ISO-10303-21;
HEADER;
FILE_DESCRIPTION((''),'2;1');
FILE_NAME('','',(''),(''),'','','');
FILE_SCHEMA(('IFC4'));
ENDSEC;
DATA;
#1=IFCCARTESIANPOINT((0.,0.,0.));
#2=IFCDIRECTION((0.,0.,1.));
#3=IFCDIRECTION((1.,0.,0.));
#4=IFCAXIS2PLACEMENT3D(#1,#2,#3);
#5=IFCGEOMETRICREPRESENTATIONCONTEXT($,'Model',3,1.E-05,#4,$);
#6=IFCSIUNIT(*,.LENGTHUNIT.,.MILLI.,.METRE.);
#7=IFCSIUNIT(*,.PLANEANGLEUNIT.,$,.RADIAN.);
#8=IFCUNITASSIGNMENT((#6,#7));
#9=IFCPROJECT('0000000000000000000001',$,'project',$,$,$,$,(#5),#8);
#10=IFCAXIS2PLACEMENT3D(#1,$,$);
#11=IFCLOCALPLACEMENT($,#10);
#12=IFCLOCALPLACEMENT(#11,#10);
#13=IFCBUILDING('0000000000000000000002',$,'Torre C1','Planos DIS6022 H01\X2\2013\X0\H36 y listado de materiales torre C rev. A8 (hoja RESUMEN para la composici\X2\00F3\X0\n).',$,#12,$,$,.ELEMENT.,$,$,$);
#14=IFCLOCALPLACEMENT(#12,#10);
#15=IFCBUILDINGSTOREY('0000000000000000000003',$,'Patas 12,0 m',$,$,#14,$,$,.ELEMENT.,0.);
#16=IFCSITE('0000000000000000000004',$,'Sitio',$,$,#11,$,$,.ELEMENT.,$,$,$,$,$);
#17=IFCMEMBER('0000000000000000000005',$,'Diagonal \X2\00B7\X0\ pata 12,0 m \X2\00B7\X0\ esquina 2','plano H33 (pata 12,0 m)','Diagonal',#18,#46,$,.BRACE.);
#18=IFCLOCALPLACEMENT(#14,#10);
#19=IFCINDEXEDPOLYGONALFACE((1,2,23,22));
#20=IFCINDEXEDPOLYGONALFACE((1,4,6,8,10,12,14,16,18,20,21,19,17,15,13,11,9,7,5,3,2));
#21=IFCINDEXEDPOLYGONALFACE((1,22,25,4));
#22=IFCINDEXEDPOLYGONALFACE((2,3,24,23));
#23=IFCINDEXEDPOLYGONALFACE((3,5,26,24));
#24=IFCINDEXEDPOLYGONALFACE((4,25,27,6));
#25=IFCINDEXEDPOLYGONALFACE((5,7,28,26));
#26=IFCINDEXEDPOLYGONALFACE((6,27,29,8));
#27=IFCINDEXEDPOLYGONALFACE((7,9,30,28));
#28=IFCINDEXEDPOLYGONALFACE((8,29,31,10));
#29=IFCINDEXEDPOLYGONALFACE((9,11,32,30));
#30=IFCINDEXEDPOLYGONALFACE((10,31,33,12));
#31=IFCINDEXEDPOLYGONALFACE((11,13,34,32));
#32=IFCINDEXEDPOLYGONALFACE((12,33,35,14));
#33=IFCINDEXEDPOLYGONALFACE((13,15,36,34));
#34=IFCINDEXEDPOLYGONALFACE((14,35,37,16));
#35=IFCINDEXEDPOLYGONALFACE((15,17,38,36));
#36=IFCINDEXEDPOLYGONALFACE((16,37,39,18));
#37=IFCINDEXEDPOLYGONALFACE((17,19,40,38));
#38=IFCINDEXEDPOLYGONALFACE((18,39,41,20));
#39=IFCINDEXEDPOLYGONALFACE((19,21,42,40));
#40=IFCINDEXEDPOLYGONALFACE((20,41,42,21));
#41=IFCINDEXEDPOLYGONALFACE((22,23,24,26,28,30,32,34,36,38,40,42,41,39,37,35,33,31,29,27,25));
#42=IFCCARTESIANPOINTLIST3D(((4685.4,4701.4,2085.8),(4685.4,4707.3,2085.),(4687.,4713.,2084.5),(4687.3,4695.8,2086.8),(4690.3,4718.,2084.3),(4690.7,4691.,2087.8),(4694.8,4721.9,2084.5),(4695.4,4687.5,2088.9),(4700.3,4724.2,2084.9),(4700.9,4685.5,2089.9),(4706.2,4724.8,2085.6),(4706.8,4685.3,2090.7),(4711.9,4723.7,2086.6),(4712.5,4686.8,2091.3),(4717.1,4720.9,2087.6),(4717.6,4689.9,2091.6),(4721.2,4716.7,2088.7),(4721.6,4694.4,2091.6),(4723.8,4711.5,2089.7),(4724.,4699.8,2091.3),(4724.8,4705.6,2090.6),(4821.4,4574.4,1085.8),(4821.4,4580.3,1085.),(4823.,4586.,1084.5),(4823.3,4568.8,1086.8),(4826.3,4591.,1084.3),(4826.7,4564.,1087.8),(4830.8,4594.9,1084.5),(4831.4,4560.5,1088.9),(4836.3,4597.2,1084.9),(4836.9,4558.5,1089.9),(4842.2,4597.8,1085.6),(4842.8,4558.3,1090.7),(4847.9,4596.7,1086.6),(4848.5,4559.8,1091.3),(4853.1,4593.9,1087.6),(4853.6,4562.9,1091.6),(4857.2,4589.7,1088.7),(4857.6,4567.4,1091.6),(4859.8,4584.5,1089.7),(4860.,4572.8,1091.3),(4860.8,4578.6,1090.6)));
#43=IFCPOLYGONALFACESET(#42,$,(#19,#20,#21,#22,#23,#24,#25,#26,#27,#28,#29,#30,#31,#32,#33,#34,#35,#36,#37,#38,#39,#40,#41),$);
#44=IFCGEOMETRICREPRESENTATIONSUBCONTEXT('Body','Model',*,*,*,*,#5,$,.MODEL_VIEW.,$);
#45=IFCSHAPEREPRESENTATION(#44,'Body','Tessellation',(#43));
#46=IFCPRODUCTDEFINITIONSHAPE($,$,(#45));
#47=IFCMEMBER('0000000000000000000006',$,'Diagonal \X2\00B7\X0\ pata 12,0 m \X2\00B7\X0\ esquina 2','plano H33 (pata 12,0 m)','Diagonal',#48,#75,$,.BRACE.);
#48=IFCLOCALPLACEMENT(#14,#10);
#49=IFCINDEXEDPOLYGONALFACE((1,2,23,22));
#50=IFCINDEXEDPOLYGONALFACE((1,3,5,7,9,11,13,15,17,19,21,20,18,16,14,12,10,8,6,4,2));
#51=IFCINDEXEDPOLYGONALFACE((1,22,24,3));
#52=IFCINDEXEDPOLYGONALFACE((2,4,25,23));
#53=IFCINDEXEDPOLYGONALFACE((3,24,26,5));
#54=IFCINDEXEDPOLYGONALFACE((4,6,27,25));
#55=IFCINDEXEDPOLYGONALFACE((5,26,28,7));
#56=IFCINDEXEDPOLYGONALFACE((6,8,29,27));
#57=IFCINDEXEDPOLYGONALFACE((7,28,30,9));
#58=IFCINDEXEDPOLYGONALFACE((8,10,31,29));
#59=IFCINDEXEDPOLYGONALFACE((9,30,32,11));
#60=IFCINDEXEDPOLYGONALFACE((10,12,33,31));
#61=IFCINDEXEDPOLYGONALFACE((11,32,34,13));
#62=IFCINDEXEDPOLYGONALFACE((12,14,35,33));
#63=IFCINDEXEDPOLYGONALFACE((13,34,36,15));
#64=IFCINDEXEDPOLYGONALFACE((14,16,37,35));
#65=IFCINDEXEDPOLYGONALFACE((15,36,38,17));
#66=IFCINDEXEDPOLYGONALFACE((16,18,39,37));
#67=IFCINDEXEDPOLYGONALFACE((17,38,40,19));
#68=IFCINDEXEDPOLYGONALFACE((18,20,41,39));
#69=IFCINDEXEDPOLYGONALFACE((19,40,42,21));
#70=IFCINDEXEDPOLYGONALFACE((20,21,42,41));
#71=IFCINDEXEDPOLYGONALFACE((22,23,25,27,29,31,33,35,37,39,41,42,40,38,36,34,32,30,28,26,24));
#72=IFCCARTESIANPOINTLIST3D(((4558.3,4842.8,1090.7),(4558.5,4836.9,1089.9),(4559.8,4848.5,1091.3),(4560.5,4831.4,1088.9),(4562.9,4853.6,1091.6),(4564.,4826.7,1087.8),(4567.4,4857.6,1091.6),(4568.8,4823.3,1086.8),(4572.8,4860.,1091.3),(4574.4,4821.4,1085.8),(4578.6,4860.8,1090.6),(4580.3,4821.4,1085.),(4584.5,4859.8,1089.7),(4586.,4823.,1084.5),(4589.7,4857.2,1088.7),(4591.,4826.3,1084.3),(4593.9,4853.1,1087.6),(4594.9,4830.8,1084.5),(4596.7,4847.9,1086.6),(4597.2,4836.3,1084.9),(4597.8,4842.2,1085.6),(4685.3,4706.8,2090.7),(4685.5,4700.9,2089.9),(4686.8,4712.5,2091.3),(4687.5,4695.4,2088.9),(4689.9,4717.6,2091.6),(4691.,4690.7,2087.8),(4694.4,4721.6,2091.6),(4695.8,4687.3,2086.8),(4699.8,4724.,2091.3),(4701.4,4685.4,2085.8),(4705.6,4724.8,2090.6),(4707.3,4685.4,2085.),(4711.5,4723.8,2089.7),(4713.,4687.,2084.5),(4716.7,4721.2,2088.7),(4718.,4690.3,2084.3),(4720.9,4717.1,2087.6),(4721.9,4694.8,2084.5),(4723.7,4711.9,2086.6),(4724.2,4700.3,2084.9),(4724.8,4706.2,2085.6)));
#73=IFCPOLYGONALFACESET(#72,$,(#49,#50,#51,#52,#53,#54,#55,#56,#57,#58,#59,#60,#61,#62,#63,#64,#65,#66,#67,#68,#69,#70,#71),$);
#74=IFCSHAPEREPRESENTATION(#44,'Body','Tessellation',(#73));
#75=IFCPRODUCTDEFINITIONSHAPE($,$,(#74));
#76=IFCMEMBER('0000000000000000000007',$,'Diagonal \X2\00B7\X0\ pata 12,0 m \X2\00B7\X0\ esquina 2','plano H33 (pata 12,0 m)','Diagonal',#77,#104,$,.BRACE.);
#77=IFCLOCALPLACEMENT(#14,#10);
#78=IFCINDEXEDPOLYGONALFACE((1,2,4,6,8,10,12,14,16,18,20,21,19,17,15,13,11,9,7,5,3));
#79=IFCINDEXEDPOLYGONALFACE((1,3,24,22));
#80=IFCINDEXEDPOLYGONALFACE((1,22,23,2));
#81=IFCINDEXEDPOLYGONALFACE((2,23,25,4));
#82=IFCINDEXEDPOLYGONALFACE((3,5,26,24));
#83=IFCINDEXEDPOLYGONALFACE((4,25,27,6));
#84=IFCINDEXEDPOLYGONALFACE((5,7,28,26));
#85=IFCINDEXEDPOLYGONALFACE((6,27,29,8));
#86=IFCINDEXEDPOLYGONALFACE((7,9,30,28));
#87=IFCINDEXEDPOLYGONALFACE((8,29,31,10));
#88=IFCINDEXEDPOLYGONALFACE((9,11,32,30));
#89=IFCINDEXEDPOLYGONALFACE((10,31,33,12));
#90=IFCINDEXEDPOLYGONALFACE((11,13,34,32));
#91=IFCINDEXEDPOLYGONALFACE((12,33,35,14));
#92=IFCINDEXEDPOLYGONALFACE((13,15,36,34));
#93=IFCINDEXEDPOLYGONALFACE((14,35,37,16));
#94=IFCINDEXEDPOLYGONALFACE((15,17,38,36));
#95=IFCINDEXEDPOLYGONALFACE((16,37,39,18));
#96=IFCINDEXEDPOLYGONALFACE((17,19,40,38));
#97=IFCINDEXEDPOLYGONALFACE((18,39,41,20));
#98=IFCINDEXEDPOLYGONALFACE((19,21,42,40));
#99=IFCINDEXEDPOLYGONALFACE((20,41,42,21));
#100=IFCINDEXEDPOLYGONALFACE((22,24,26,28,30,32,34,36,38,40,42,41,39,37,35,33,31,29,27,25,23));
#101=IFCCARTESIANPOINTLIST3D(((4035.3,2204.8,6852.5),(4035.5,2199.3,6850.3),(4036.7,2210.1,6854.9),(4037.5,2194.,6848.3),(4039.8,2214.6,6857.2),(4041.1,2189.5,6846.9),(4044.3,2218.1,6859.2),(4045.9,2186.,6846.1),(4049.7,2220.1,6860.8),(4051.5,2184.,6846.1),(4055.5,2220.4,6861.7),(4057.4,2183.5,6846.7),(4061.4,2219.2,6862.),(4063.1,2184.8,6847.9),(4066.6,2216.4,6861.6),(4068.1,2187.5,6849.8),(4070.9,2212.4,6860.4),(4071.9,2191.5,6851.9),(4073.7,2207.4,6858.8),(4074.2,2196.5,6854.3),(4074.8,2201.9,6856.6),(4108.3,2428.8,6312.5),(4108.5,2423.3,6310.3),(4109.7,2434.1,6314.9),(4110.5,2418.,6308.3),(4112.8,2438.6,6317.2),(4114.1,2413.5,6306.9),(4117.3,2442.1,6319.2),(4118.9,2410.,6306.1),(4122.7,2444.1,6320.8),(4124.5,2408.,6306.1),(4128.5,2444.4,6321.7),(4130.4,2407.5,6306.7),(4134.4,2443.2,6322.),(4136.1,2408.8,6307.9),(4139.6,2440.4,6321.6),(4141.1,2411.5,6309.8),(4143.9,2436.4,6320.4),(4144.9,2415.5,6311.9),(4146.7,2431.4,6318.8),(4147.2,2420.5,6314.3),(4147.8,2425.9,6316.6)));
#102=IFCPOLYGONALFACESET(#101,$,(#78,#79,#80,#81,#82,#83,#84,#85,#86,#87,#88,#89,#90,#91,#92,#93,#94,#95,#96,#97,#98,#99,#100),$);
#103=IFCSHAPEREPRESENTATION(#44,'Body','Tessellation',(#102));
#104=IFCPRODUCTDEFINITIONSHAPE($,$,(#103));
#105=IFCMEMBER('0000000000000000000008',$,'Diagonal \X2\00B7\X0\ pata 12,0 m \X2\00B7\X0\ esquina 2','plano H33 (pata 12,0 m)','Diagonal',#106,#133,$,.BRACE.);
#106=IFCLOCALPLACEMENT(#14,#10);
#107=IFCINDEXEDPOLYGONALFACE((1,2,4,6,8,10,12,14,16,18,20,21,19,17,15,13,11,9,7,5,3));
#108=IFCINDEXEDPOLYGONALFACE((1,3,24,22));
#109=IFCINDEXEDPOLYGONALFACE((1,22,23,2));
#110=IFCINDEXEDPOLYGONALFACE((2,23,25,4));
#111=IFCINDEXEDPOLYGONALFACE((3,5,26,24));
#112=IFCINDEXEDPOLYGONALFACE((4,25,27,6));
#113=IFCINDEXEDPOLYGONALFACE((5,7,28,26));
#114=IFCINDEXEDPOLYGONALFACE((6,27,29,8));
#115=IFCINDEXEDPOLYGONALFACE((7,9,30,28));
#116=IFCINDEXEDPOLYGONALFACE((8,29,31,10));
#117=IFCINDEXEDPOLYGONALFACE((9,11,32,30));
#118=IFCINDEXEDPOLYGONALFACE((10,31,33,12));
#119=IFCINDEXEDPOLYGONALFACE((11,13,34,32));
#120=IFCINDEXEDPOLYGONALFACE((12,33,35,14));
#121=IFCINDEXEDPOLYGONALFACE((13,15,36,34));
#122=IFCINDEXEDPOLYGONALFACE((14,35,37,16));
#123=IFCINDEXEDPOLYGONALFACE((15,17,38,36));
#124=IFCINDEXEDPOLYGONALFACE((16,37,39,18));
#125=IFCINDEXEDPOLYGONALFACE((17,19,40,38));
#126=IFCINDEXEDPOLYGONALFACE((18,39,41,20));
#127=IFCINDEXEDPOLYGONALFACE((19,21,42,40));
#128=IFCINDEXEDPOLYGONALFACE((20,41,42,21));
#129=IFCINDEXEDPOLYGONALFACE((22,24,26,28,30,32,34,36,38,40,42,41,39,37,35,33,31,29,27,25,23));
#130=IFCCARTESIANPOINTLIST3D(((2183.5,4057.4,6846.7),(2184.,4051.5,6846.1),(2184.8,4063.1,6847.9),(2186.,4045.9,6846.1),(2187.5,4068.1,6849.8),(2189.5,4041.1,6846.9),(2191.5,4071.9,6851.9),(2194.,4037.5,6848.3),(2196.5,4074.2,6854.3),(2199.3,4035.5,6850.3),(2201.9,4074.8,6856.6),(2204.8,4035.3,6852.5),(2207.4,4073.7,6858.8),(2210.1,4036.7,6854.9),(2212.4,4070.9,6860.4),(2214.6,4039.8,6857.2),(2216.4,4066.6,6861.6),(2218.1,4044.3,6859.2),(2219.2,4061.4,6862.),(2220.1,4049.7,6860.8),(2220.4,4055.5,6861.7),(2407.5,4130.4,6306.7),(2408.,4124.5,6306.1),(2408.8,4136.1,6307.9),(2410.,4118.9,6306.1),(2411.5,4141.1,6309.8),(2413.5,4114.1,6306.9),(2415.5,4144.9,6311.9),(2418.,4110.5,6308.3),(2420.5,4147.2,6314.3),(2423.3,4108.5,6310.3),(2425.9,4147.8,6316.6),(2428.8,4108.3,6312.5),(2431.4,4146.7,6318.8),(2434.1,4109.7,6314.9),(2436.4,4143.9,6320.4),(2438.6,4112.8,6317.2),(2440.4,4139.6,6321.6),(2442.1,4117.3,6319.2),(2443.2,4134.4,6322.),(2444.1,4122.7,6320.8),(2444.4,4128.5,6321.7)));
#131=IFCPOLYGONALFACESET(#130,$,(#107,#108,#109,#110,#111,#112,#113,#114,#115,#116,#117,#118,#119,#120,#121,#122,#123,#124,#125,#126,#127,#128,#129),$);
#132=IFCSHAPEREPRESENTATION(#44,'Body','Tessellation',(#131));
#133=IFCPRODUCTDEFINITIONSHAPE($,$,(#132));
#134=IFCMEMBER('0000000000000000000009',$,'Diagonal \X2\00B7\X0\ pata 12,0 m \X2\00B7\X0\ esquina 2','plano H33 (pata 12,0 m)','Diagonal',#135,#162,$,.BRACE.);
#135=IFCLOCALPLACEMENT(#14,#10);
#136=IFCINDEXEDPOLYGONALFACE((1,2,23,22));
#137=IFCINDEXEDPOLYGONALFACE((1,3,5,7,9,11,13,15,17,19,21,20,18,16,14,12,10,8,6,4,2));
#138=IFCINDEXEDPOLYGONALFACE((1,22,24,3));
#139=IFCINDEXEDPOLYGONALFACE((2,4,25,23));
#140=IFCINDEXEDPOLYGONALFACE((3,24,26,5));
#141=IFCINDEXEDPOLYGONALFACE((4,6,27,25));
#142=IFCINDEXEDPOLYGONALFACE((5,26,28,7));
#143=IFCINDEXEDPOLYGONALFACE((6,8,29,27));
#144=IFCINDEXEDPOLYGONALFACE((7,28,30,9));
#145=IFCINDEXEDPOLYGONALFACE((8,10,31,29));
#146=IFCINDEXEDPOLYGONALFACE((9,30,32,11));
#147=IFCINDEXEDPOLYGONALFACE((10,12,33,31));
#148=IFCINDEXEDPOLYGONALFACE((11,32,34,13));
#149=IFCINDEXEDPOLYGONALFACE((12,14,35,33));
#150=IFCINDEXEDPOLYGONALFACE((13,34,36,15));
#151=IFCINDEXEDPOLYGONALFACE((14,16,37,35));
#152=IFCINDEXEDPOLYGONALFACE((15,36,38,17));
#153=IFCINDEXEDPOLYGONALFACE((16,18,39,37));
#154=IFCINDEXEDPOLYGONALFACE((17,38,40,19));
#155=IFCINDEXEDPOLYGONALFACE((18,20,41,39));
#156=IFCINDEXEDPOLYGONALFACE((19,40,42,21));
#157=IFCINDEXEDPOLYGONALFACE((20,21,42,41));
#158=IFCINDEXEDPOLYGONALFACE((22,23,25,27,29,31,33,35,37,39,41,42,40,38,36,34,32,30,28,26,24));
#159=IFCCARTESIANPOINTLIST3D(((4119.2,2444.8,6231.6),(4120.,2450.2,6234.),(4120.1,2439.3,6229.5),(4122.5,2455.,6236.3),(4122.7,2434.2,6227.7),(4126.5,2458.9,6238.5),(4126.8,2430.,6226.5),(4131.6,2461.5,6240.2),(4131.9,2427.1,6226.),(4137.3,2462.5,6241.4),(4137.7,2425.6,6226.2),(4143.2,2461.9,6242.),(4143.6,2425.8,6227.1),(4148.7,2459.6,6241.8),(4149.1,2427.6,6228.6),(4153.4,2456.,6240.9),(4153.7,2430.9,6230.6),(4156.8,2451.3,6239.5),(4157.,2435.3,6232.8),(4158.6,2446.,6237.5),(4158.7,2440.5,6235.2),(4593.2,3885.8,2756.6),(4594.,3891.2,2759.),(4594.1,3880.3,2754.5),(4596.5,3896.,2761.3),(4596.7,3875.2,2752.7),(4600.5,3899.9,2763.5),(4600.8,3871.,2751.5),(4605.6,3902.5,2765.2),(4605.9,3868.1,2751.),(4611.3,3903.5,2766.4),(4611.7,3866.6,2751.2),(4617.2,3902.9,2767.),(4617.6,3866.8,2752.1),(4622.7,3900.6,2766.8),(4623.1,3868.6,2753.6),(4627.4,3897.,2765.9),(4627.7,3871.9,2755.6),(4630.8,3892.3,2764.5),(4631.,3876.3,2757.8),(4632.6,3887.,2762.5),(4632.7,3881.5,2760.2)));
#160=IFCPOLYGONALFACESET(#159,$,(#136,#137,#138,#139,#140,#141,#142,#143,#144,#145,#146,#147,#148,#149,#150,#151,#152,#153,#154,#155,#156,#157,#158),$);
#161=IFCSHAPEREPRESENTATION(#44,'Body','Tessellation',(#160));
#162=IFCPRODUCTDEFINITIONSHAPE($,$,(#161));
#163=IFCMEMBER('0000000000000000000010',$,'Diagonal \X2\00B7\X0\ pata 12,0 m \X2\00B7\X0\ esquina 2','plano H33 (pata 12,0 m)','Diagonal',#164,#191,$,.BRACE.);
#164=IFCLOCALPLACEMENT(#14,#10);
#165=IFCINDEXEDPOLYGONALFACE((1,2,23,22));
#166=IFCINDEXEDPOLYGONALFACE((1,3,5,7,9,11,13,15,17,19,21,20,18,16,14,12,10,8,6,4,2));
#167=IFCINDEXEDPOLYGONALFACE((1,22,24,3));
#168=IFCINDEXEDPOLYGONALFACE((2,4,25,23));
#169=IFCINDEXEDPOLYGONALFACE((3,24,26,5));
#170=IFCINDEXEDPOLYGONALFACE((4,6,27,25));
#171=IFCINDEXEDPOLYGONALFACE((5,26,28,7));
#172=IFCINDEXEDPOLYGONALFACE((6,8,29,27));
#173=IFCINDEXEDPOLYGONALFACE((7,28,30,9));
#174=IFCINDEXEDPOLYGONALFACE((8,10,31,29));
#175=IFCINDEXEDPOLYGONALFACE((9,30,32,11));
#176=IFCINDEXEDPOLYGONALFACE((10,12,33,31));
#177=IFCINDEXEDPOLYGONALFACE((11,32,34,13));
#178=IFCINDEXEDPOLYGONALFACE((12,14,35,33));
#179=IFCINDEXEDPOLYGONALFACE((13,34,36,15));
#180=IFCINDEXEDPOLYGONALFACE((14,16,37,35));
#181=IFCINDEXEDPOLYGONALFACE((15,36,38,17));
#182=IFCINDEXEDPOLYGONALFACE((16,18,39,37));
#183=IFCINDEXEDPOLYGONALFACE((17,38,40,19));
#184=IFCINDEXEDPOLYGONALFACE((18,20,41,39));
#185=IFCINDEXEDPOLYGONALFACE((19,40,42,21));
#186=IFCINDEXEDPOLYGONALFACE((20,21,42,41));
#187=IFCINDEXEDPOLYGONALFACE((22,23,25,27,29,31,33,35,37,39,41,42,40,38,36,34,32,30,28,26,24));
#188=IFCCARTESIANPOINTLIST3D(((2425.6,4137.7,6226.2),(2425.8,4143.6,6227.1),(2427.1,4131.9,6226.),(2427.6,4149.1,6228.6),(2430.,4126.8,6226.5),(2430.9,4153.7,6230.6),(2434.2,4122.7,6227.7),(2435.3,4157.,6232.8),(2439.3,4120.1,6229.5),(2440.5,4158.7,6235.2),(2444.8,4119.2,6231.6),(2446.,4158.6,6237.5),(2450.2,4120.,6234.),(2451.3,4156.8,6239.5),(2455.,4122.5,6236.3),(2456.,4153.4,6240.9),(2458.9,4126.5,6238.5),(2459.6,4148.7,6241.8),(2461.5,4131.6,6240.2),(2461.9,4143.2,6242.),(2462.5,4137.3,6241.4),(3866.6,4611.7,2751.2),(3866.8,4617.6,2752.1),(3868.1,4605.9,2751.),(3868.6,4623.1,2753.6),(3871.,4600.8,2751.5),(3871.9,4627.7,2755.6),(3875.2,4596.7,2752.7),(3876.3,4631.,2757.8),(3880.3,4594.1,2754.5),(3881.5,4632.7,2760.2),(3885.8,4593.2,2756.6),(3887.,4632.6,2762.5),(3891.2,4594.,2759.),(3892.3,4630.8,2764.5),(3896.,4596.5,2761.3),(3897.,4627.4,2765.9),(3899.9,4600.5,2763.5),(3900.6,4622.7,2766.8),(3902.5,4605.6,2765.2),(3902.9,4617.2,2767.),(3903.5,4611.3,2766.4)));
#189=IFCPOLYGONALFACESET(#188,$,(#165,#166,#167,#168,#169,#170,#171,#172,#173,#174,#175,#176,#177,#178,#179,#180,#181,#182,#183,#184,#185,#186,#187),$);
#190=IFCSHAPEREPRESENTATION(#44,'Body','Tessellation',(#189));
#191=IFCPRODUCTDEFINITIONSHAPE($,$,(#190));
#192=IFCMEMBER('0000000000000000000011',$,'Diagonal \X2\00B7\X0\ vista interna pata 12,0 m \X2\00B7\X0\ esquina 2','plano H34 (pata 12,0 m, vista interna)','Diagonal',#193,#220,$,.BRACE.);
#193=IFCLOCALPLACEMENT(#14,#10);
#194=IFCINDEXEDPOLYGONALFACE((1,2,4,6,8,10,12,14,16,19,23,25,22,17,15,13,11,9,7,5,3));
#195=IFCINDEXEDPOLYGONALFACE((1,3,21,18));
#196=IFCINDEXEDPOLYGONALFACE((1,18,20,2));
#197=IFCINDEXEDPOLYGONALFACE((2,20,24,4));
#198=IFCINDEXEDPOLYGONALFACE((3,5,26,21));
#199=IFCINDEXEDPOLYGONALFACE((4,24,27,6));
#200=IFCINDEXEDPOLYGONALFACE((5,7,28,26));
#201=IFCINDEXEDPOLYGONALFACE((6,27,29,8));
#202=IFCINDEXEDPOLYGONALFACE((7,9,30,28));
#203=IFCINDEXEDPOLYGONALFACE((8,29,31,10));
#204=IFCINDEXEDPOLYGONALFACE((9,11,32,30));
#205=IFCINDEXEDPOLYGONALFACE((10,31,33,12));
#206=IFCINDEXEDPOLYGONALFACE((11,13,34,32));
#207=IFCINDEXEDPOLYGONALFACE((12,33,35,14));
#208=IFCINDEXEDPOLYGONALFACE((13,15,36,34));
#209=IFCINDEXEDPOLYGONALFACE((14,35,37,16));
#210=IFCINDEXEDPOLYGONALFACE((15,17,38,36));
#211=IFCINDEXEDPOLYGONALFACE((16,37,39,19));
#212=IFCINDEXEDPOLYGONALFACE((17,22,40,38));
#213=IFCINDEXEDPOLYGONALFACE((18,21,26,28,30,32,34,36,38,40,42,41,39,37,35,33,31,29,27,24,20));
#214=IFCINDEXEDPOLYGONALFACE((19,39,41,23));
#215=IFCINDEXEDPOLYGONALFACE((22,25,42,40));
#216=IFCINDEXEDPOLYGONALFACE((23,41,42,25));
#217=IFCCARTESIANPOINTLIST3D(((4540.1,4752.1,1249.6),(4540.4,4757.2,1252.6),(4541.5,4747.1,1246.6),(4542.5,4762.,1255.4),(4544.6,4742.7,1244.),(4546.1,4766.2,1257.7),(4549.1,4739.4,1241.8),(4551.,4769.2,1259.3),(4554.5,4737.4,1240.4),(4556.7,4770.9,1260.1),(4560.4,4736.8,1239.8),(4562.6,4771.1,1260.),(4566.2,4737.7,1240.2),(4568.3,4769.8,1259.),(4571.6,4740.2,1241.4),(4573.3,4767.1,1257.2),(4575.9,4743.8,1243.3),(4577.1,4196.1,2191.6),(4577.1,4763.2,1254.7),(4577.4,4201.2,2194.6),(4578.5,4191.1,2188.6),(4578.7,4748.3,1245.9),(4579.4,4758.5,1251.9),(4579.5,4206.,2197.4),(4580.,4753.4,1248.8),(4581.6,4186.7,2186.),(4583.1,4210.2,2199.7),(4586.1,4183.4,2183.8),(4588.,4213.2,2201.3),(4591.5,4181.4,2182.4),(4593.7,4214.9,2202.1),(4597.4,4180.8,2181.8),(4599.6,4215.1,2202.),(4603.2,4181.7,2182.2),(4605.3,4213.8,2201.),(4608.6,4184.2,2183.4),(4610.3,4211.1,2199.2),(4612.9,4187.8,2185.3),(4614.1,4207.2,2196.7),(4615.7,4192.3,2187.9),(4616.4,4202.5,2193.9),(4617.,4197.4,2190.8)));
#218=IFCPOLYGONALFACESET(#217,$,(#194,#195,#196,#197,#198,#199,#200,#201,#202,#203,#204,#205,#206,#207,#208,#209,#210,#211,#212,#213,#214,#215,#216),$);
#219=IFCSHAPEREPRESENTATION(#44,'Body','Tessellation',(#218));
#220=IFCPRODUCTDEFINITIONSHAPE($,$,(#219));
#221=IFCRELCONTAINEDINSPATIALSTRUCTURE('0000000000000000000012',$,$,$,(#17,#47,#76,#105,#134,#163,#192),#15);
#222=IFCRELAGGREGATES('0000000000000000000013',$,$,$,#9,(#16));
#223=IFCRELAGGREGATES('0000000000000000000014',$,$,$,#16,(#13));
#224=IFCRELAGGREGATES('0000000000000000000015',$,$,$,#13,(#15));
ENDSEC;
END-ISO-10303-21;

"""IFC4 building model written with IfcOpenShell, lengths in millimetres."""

from ifc_helpers import new_model, si_unit, frame, origin, origin_with_axes, place, context, subcontext, project, spatial, circle, extrude, element, save


model = new_model("IFC4")

# Units and contexts
model_context = context("Model", 3, precision=1e-05, world=origin_with_axes())
body_context = subcontext(model_context, "Body", "Model", "MODEL_VIEW")
ifc_project = project(units=[si_unit("LENGTHUNIT", "METRE", prefix="MILLI"), si_unit("PLANEANGLEUNIT", "RADIAN")], contexts=[model_context])

# Site, building, storey
site_placement = place(None, origin())
site = spatial("IfcSite", under=ifc_project, at=site_placement, Name="Sitio", CompositionType="ELEMENT")
building_placement = place(site_placement, origin())
building = spatial("IfcBuilding", under=site, at=building_placement, Name="Torre C1", Description="Planos DIS6022 H01–H36 y listado de materiales torre C rev. A8 (hoja RESUMEN para la composición).", CompositionType="ELEMENT")
storey_placement = place(building_placement, origin())
storey = spatial("IfcBuildingStorey", under=building, at=storey_placement, Name="Patas 12,0 m", CompositionType="ELEMENT", Elevation=0.0)

# Members
for number, where, z_axis, x_axis, name in (
    (1, (4705.0, 4705.0, 2088.0), (0.133705, -0.124857, -0.983124), (-0.715763, -0.698289, -0.008661), "Diagonal · pata 12,0 m · esquina 2"),
    (2, (4705.0, 4705.0, 2088.0), (-0.124857, 0.133705, -0.983124), (-0.698289, -0.715763, -0.008661), "Diagonal · pata 12,0 m · esquina 2"),
):
    element("IfcMember", number, at=place(storey_placement, frame(where, z_axis=z_axis, x_axis=x_axis)), inside=storey, Name=name, Description="plano H33 (pata 12,0 m)", ObjectType="Diagonal", PredefinedType="BRACE", context=body_context, shape_type="SweptSolid", body=[
        extrude(circle(Radius=20.0), None, (0.0, 0.0, 1.0), 1017.2),
    ])
for number, where, z_axis, x_axis, name in (
    (3, (4055.0, 2202.0, 6854.0), (0.123906, 0.380205, -0.916565), (-0.872723, -0.397823, -0.283002), "Diagonal · pata 12,0 m · esquina 2"),
    (4, (2202.0, 4055.0, 6854.0), (0.380205, 0.123906, -0.916565), (-0.397823, -0.872723, -0.283002), "Diagonal · pata 12,0 m · esquina 2"),
):
    element("IfcMember", number, at=place(storey_placement, frame(where, z_axis=z_axis, x_axis=x_axis)), inside=storey, Name=name, Description="plano H33 (pata 12,0 m)", ObjectType="Diagonal", PredefinedType="BRACE", context=body_context, shape_type="SweptSolid", body=[
        extrude(circle(Radius=20.0), None, (0.0, 0.0, 1.0), 589.2),
    ])
for number, where, z_axis, x_axis, name in (
    (5, (4139.0, 2444.0, 6234.0), (0.125011, 0.380043, -0.916482), (-0.813713, -0.489241, -0.31387), "Diagonal · pata 12,0 m · esquina 2"),
    (6, (2444.0, 4139.0, 6234.0), (0.380043, 0.125011, -0.916482), (-0.489241, -0.813713, -0.31387), "Diagonal · pata 12,0 m · esquina 2"),
):
    element("IfcMember", number, at=place(storey_placement, frame(where, z_axis=z_axis, x_axis=x_axis)), inside=storey, Name=name, Description="plano H33 (pata 12,0 m)", ObjectType="Diagonal", PredefinedType="BRACE", context=body_context, shape_type="SweptSolid", body=[
        extrude(circle(Radius=20.0), None, (0.0, 0.0, 1.0), 3791.7),
    ])
member_1_placement = place(storey_placement, frame((4597.0, 4198.0, 2192.0), z_axis=(-0.033806, 0.508008, -0.860689), x_axis=(-0.769624, -0.562637, -0.301858)))
element("IfcMember", 7, at=member_1_placement, inside=storey, Name="Diagonal · vista interna pata 12,0 m · esquina 2", Description="plano H34 (pata 12,0 m, vista interna)", ObjectType="Diagonal", PredefinedType="BRACE", context=body_context, shape_type="SweptSolid", body=[
    extrude(circle(Radius=20.0), None, (0.0, 0.0, 1.0), 1094.5),
])

save(model, "model.ifc")
